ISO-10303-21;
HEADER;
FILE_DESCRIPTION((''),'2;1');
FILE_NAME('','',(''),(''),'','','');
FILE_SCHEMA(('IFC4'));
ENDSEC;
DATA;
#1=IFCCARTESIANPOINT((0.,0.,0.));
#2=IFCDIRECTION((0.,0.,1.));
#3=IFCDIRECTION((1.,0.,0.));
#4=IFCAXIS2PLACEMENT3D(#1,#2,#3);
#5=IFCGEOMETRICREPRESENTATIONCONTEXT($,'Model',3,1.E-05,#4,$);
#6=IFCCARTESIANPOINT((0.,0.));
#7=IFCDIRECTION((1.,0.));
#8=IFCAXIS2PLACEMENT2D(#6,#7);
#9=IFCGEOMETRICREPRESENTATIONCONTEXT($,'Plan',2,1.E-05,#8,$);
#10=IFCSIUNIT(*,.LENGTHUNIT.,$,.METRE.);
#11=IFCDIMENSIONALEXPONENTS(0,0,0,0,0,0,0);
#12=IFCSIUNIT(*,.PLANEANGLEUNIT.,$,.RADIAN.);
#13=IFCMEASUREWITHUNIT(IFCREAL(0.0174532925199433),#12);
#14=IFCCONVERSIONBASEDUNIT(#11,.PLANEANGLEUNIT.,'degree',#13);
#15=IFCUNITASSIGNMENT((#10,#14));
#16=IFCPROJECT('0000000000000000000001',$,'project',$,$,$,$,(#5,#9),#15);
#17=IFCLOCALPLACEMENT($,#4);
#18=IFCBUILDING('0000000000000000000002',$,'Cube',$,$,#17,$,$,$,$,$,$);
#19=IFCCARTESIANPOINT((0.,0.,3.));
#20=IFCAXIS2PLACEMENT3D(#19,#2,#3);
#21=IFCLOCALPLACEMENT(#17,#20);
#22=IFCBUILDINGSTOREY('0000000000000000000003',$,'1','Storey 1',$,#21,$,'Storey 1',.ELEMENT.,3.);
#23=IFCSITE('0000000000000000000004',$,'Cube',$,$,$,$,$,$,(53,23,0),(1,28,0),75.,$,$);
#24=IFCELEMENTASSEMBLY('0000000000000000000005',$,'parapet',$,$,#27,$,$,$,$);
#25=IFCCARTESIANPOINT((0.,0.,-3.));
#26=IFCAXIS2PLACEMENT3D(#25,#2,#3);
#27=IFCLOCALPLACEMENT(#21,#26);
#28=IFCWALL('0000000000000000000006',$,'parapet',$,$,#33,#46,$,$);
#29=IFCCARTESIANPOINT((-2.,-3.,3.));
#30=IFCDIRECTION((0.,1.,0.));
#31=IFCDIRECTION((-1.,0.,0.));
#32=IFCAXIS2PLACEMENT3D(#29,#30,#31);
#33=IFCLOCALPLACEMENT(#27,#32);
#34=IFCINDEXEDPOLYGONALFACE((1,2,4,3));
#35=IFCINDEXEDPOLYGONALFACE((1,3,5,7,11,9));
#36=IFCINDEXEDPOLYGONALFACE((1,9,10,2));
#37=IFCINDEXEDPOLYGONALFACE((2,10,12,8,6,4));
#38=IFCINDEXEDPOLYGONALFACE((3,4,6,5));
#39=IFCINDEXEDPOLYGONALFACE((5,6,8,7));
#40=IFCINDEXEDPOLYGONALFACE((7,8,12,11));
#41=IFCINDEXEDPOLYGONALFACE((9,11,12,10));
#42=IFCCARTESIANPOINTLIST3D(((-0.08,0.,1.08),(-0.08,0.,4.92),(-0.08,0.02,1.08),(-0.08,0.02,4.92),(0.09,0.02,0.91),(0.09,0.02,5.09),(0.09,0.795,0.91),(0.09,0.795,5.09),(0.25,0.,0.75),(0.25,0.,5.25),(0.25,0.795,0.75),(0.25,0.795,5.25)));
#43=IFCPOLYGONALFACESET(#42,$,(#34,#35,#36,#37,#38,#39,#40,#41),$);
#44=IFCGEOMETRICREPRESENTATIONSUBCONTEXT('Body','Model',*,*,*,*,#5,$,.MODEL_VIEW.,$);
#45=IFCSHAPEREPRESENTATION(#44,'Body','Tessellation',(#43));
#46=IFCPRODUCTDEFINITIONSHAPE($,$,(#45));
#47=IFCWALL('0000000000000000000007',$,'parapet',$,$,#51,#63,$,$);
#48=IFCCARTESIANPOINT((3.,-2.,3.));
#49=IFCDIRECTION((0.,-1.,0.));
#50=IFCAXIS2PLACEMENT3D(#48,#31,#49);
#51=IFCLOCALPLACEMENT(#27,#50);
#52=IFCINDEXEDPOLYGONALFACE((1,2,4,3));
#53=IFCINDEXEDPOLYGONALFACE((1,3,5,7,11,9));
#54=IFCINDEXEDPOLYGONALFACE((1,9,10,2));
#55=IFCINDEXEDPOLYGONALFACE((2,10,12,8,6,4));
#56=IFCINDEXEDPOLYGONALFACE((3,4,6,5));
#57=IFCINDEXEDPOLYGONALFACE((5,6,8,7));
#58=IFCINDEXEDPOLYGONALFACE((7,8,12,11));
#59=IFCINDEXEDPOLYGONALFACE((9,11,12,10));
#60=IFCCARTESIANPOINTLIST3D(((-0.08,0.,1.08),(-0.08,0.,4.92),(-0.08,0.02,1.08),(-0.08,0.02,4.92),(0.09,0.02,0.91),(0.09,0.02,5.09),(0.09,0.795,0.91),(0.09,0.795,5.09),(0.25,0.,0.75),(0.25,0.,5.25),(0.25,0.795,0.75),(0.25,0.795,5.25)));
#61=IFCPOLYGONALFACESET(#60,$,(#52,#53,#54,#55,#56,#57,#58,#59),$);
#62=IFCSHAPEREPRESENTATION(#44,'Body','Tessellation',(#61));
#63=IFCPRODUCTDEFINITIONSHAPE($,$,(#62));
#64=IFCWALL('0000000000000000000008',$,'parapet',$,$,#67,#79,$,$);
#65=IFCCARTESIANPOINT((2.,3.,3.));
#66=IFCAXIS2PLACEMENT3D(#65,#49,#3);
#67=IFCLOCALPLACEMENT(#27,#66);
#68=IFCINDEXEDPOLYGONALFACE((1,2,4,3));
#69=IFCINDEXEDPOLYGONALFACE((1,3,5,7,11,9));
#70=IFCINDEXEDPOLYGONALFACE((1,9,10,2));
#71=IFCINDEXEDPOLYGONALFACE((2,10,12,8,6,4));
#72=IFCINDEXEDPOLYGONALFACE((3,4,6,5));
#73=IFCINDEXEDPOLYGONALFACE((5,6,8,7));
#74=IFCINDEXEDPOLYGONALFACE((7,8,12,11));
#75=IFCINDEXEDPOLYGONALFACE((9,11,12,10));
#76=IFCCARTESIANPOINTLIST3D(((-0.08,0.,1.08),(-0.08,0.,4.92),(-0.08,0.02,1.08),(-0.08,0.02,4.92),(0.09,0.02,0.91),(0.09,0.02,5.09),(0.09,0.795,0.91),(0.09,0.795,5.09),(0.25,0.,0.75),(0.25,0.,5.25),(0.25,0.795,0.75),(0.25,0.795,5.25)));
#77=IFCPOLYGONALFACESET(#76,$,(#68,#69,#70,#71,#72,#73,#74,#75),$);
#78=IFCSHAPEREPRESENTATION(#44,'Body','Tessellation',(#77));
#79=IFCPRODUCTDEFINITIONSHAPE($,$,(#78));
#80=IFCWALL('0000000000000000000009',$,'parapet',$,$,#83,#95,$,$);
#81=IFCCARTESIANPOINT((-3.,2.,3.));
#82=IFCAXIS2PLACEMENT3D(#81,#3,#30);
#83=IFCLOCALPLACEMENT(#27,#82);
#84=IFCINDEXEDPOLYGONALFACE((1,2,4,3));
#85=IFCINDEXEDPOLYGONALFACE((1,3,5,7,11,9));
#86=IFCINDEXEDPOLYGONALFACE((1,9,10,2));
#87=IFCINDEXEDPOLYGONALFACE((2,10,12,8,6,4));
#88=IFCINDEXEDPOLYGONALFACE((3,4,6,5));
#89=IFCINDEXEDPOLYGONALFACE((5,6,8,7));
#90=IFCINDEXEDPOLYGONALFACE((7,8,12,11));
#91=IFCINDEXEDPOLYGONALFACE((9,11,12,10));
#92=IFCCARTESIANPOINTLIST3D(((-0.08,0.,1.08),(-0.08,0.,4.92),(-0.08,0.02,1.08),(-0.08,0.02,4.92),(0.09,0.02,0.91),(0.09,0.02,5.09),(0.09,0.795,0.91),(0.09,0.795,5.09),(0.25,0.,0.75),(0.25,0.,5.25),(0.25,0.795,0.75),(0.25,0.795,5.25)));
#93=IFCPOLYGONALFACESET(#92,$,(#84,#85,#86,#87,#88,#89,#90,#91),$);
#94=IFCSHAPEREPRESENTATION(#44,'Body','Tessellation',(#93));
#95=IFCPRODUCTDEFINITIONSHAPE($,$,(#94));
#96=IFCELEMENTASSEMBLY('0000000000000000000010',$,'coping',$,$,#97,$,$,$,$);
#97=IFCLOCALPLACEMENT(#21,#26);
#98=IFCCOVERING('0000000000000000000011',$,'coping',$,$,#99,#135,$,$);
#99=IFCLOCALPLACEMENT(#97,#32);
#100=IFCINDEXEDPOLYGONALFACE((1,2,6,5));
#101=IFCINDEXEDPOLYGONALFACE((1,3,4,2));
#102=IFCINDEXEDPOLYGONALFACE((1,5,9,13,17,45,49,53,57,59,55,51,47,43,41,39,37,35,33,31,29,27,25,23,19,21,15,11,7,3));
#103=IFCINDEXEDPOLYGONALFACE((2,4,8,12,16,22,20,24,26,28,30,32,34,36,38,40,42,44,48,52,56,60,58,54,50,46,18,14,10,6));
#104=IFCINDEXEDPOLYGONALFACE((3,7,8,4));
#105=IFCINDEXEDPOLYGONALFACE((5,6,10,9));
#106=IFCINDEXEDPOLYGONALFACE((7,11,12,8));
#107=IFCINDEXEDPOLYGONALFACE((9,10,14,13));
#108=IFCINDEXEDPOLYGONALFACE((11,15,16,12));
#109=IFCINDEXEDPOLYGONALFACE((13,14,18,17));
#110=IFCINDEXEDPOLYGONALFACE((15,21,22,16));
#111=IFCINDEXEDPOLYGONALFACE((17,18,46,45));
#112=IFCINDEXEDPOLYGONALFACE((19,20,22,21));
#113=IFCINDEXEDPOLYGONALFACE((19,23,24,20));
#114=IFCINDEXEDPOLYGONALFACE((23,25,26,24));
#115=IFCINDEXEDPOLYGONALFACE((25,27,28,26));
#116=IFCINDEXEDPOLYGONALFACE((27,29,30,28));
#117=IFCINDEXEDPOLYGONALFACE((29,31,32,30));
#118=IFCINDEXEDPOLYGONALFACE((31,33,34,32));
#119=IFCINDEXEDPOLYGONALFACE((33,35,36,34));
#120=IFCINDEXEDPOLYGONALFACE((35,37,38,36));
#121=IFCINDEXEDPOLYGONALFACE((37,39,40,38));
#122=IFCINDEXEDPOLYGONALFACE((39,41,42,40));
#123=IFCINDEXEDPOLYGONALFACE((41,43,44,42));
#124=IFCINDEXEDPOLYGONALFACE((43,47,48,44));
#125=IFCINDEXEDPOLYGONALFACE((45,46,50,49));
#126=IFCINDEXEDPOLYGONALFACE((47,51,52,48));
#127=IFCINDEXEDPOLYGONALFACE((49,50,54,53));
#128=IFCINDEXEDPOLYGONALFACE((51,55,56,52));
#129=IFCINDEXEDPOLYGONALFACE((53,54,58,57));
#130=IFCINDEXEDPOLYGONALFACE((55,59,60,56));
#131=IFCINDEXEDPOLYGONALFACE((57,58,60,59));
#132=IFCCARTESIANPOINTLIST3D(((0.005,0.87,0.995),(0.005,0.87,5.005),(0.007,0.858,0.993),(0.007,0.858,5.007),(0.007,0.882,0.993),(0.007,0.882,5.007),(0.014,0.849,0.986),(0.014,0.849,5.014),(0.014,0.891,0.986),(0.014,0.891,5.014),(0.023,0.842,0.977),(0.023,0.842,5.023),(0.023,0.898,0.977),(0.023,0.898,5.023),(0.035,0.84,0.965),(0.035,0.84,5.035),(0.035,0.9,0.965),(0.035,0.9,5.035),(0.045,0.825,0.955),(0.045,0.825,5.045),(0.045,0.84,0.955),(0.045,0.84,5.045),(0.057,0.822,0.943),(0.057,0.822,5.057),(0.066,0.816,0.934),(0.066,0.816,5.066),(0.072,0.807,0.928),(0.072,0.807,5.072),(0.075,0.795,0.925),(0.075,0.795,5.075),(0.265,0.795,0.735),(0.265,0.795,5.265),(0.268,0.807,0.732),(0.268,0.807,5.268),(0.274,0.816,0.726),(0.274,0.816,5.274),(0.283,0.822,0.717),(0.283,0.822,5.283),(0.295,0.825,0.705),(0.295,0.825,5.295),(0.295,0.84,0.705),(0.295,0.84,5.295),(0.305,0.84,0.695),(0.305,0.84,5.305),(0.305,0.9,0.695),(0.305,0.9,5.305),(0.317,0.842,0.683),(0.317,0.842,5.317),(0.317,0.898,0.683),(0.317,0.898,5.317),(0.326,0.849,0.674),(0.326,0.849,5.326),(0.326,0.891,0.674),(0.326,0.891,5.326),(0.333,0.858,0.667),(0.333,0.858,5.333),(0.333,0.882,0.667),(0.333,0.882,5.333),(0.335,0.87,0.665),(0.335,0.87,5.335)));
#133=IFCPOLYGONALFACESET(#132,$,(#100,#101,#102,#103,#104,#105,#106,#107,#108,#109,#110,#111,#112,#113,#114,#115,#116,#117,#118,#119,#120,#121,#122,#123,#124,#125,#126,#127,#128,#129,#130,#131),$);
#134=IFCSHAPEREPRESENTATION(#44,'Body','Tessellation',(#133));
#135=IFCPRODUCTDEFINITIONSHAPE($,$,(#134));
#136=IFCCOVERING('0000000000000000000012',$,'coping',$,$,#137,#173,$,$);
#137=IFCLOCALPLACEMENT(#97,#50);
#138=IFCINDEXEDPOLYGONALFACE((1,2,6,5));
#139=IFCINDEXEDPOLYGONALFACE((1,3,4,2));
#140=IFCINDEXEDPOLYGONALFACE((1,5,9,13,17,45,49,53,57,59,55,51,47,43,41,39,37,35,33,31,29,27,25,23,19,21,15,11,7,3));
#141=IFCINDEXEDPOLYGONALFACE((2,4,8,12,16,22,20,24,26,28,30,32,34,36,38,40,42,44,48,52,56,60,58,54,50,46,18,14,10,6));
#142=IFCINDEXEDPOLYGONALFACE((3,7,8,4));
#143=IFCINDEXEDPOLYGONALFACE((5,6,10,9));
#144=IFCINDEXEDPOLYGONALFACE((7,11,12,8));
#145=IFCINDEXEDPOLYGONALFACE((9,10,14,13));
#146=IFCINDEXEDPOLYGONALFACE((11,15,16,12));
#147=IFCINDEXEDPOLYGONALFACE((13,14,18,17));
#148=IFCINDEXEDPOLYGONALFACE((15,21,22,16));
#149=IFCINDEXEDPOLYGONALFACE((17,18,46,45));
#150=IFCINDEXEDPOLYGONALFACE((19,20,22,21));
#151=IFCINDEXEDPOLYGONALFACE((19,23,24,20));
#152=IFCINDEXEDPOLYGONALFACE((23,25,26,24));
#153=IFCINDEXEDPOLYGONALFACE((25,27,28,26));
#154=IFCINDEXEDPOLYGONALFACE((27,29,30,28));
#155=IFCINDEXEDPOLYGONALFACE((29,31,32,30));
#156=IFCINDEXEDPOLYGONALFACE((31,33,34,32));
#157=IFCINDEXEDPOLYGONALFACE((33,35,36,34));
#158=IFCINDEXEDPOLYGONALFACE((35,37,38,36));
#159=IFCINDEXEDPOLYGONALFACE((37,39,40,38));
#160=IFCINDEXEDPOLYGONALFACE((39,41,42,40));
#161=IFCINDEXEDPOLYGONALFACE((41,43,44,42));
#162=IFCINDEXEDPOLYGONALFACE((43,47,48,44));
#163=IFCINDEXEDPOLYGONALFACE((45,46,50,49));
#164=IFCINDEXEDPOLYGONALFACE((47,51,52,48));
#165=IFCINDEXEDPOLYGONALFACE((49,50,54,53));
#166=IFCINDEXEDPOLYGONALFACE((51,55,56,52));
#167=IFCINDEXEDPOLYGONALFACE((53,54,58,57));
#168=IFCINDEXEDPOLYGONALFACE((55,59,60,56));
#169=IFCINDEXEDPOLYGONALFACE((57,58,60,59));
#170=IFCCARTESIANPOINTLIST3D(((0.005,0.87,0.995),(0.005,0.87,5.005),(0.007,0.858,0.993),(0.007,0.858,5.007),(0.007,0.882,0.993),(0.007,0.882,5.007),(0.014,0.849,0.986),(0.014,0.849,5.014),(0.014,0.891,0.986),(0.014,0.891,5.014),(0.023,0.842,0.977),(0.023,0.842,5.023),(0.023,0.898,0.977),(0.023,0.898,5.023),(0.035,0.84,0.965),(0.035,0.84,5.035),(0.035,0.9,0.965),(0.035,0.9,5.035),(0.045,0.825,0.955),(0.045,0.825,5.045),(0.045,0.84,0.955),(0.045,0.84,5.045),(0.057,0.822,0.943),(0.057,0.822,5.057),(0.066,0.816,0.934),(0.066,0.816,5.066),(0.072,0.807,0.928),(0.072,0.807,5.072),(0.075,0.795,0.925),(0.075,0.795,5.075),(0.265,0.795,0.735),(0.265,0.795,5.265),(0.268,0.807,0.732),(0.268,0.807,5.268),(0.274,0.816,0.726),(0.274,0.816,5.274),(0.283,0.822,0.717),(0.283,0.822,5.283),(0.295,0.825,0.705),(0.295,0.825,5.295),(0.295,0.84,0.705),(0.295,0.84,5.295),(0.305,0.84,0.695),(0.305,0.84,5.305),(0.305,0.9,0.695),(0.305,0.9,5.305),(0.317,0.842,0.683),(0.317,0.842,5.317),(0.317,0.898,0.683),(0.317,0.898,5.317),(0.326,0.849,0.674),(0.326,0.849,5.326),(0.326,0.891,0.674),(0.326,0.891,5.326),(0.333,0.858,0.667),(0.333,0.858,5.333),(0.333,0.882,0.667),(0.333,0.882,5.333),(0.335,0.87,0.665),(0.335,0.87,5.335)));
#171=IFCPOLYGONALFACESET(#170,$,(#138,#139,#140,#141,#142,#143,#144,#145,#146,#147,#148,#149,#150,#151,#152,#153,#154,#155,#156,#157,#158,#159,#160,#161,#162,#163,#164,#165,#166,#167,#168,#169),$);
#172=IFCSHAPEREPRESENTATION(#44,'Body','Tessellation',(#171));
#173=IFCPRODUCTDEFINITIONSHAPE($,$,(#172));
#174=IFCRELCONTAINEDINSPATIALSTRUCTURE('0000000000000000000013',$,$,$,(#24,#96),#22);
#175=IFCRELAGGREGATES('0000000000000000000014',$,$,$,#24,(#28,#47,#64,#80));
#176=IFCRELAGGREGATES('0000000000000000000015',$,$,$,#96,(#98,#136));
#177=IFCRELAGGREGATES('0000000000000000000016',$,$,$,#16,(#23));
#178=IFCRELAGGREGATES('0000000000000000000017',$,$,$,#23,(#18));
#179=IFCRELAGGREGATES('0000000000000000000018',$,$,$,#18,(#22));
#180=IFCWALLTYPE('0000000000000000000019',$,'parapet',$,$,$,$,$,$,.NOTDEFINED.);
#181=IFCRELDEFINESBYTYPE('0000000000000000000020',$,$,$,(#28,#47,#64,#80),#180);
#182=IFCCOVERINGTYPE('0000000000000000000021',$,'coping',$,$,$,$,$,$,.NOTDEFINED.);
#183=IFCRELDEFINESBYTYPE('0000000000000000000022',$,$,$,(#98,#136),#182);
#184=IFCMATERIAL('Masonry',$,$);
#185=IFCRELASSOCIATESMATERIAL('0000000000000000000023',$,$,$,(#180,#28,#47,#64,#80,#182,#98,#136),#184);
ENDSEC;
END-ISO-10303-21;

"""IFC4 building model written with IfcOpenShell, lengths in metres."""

from ifc_helpers import new_model, entity, si_unit, converted_unit, frame, origin_with_axes, origin_2d_with_axis, place, context, subcontext, project, spatial, polyline, outline, extrude, clip, halfspace, material, material_profile, profile_set, profile_usage, type_object, element, aggregate, save


model = new_model("IFC4")

# Units and contexts
model_context = context("Model", 3, precision=1e-05, world=origin_with_axes())
plan_context = context("Plan", 2, precision=1e-05, world=origin_2d_with_axis())
body_context = subcontext(model_context, "Body", "Model", "MODEL_VIEW")
ifc_project = project(units=[si_unit("LENGTHUNIT", "METRE"), converted_unit("PLANEANGLEUNIT", "degree", entity("IfcReal", 0.0174532925199433), si_unit("PLANEANGLEUNIT", "RADIAN"), dimensions=[0, 0, 0, 0, 0, 0, 0])], contexts=[model_context, plan_context])

# Site, building, storey
site = spatial("IfcSite", under=ifc_project, Name="Cube", RefLatitude=(53, 23, 0), RefLongitude=(1, 28, 0), RefElevation=75.0)
building_placement = place(None, origin_with_axes())
building = spatial("IfcBuilding", under=site, at=building_placement, Name="Cube")
storey_placement = place(building_placement, frame((0.0, 0.0, 3.0), z_axis=(0.0, 0.0, 1.0), x_axis=(1.0, 0.0, 0.0)))
storey = spatial("IfcBuildingStorey", under=building, at=storey_placement, Name="1", Description="Storey 1", LongName="Storey 1", CompositionType="ELEMENT", Elevation=3.0)

# Element assembly, walls
assembly_1_placement = place(storey_placement, frame((0.0, 0.0, -3.0), z_axis=(0.0, 0.0, 1.0), x_axis=(1.0, 0.0, 0.0)))
assembly_1 = element("IfcElementAssembly", 1, at=assembly_1_placement, inside=storey, Name="parapet")
ifc_material_1 = material(Name="Masonry")
ifc_material_profile_1 = material_profile(ifc_material_1, outline(polyline([(0.25, 0.0), (0.25, 0.795), (0.09, 0.795), (0.09, 0.02), (-0.08, 0.02), (-0.08, 0.0), (0.25, 0.0)])))
ifc_profile_set_1 = profile_set([ifc_material_profile_1])
ifc_profile_usage_1 = profile_usage(ifc_profile_set_1)
wall_type = type_object("IfcWallType", Name="parapet", PredefinedType="NOTDEFINED", material=ifc_profile_set_1)
wall_1_placement = place(assembly_1_placement, frame((-2.0, -3.0, 3.0), z_axis=(0.0, 1.0, 0.0), x_axis=(-1.0, 0.0, 0.0)))
wall_1 = element("IfcWall", 2, at=wall_1_placement, type_object=wall_type, material=ifc_profile_usage_1, Name="parapet", context=body_context, shape_type="Clipping", body=[
    clip(clip(extrude(outline(polyline([(0.25, 0.0), (0.25, 0.795), (0.09, 0.795), (0.09, 0.02), (-0.08, 0.02), (-0.08, 0.0), (0.25, 0.0)])), origin_with_axes(), (0.0, 0.0, 1.0), 6.0), halfspace(frame((0.0, -3.0, 1.0), z_axis=(-0.707107, 0.0, -0.707107), x_axis=(0.0, 1.0, 0.0)), False)), halfspace(frame((0.0, -3.0, 5.0), z_axis=(-0.707107, 0.0, 0.707107), x_axis=(0.0, 1.0, 0.0)), False)),
])
ifc_profile_usage_2 = profile_usage(ifc_profile_set_1)
wall_2_placement = place(assembly_1_placement, frame((3.0, -2.0, 3.0), z_axis=(-1.0, 0.0, 0.0), x_axis=(0.0, -1.0, 0.0)))
wall_2 = element("IfcWall", 3, at=wall_2_placement, type_object=wall_type, material=ifc_profile_usage_2, Name="parapet", context=body_context, shape_type="Clipping", body=[
    clip(clip(extrude(outline(polyline([(0.25, 0.0), (0.25, 0.795), (0.09, 0.795), (0.09, 0.02), (-0.08, 0.02), (-0.08, 0.0), (0.25, 0.0)])), origin_with_axes(), (0.0, 0.0, 1.0), 6.0), halfspace(frame((0.0, -3.0, 1.0), z_axis=(-0.707107, 0.0, -0.707107), x_axis=(0.0, 1.0, 0.0)), False)), halfspace(frame((0.0, -3.0, 5.0), z_axis=(-0.707107, 0.0, 0.707107), x_axis=(0.0, 1.0, 0.0)), False)),
])
ifc_profile_usage_3 = profile_usage(ifc_profile_set_1)
wall_3_placement = place(assembly_1_placement, frame((2.0, 3.0, 3.0), z_axis=(0.0, -1.0, 0.0), x_axis=(1.0, 0.0, 0.0)))
wall_3 = element("IfcWall", 4, at=wall_3_placement, type_object=wall_type, material=ifc_profile_usage_3, Name="parapet", context=body_context, shape_type="Clipping", body=[
    clip(clip(extrude(outline(polyline([(0.25, 0.0), (0.25, 0.795), (0.09, 0.795), (0.09, 0.02), (-0.08, 0.02), (-0.08, 0.0), (0.25, 0.0)])), origin_with_axes(), (0.0, 0.0, 1.0), 6.0), halfspace(frame((0.0, -3.0, 1.0), z_axis=(-0.707107, 0.0, -0.707107), x_axis=(0.0, 1.0, 0.0)), False)), halfspace(frame((0.0, -3.0, 5.0), z_axis=(-0.707107, 0.0, 0.707107), x_axis=(0.0, 1.0, 0.0)), False)),
])
ifc_profile_usage_4 = profile_usage(ifc_profile_set_1)
wall_4_placement = place(assembly_1_placement, frame((-3.0, 2.0, 3.0), z_axis=(1.0, 0.0, 0.0), x_axis=(0.0, 1.0, 0.0)))
wall_4 = element("IfcWall", 5, at=wall_4_placement, type_object=wall_type, material=ifc_profile_usage_4, Name="parapet", context=body_context, shape_type="Clipping", body=[
    clip(clip(extrude(outline(polyline([(0.25, 0.0), (0.25, 0.795), (0.09, 0.795), (0.09, 0.02), (-0.08, 0.02), (-0.08, 0.0), (0.25, 0.0)])), origin_with_axes(), (0.0, 0.0, 1.0), 6.0), halfspace(frame((0.0, -3.0, 1.0), z_axis=(-0.707107, 0.0, -0.707107), x_axis=(0.0, 1.0, 0.0)), False)), halfspace(frame((0.0, -3.0, 5.0), z_axis=(-0.707107, 0.0, 0.707107), x_axis=(0.0, 1.0, 0.0)), False)),
])
aggregate(assembly_1, [wall_1, wall_2, wall_3, wall_4])

# Element assembly, coverings
assembly_2_placement = place(storey_placement, frame((0.0, 0.0, -3.0), z_axis=(0.0, 0.0, 1.0), x_axis=(1.0, 0.0, 0.0)))
assembly_2 = element("IfcElementAssembly", 6, at=assembly_2_placement, inside=storey, Name="coping")
ifc_material_profile_2 = material_profile(ifc_material_1, outline(polyline([(0.265, 0.795), (0.268, 0.807), (0.274, 0.816), (0.283, 0.822), (0.295, 0.825), (0.295, 0.84), (0.305, 0.84), (0.317, 0.842), (0.326, 0.849), (0.333, 0.858), (0.335, 0.87), (0.333, 0.882), (0.326, 0.891), (0.317, 0.898), (0.305, 0.9), (0.035, 0.9), (0.023, 0.898), (0.014, 0.891), (0.007, 0.882), (0.005, 0.87), (0.007, 0.858), (0.014, 0.849), (0.023, 0.842), (0.035, 0.84), (0.045, 0.84), (0.045, 0.825), (0.057, 0.822), (0.066, 0.816), (0.072, 0.807), (0.075, 0.795), (0.265, 0.795)])))
ifc_profile_set_2 = profile_set([ifc_material_profile_2])
ifc_profile_usage_5 = profile_usage(ifc_profile_set_2)
covering_type_1 = type_object("IfcCoveringType", Name="coping", PredefinedType="NOTDEFINED", material=ifc_profile_set_2)
covering_1_placement = place(assembly_2_placement, frame((-2.0, -3.0, 3.0), z_axis=(0.0, 1.0, 0.0), x_axis=(-1.0, 0.0, 0.0)))
covering_1 = element("IfcCovering", 7, at=covering_1_placement, type_object=covering_type_1, material=ifc_profile_usage_5, Name="coping", context=body_context, shape_type="Clipping", body=[
    clip(clip(extrude(outline(polyline([(0.265, 0.795), (0.268, 0.807), (0.274, 0.816), (0.283, 0.822), (0.295, 0.825), (0.295, 0.84), (0.305, 0.84), (0.317, 0.842), (0.326, 0.849), (0.333, 0.858), (0.335, 0.87), (0.333, 0.882), (0.326, 0.891), (0.317, 0.898), (0.305, 0.9), (0.035, 0.9), (0.023, 0.898), (0.014, 0.891), (0.007, 0.882), (0.005, 0.87), (0.007, 0.858), (0.014, 0.849), (0.023, 0.842), (0.035, 0.84), (0.045, 0.84), (0.045, 0.825), (0.057, 0.822), (0.066, 0.816), (0.072, 0.807), (0.075, 0.795), (0.265, 0.795)])), origin_with_axes(), (0.0, 0.0, 1.0), 6.0), halfspace(frame((0.0, -3.0, 1.0), z_axis=(-0.707107, 0.0, -0.707107), x_axis=(0.0, 1.0, 0.0)), False)), halfspace(frame((0.0, -3.0, 5.0), z_axis=(-0.707107, 0.0, 0.707107), x_axis=(0.0, 1.0, 0.0)), False)),
])
ifc_profile_usage_6 = profile_usage(ifc_profile_set_2)
covering_2_placement = place(assembly_2_placement, frame((3.0, -2.0, 3.0), z_axis=(-1.0, 0.0, 0.0), x_axis=(0.0, -1.0, 0.0)))
covering_2 = element("IfcCovering", 8, at=covering_2_placement, type_object=covering_type_1, material=ifc_profile_usage_6, Name="coping", context=body_context, shape_type="Clipping", body=[
    clip(clip(extrude(outline(polyline([(0.265, 0.795), (0.268, 0.807), (0.274, 0.816), (0.283, 0.822), (0.295, 0.825), (0.295, 0.84), (0.305, 0.84), (0.317, 0.842), (0.326, 0.849), (0.333, 0.858), (0.335, 0.87), (0.333, 0.882), (0.326, 0.891), (0.317, 0.898), (0.305, 0.9), (0.035, 0.9), (0.023, 0.898), (0.014, 0.891), (0.007, 0.882), (0.005, 0.87), (0.007, 0.858), (0.014, 0.849), (0.023, 0.842), (0.035, 0.84), (0.045, 0.84), (0.045, 0.825), (0.057, 0.822), (0.066, 0.816), (0.072, 0.807), (0.075, 0.795), (0.265, 0.795)])), origin_with_axes(), (0.0, 0.0, 1.0), 6.0), halfspace(frame((0.0, -3.0, 1.0), z_axis=(-0.707107, 0.0, -0.707107), x_axis=(0.0, 1.0, 0.0)), False)), halfspace(frame((0.0, -3.0, 5.0), z_axis=(-0.707107, 0.0, 0.707107), x_axis=(0.0, 1.0, 0.0)), False)),
])
aggregate(assembly_2, [covering_1, covering_2])

save(model, "model.ifc")
